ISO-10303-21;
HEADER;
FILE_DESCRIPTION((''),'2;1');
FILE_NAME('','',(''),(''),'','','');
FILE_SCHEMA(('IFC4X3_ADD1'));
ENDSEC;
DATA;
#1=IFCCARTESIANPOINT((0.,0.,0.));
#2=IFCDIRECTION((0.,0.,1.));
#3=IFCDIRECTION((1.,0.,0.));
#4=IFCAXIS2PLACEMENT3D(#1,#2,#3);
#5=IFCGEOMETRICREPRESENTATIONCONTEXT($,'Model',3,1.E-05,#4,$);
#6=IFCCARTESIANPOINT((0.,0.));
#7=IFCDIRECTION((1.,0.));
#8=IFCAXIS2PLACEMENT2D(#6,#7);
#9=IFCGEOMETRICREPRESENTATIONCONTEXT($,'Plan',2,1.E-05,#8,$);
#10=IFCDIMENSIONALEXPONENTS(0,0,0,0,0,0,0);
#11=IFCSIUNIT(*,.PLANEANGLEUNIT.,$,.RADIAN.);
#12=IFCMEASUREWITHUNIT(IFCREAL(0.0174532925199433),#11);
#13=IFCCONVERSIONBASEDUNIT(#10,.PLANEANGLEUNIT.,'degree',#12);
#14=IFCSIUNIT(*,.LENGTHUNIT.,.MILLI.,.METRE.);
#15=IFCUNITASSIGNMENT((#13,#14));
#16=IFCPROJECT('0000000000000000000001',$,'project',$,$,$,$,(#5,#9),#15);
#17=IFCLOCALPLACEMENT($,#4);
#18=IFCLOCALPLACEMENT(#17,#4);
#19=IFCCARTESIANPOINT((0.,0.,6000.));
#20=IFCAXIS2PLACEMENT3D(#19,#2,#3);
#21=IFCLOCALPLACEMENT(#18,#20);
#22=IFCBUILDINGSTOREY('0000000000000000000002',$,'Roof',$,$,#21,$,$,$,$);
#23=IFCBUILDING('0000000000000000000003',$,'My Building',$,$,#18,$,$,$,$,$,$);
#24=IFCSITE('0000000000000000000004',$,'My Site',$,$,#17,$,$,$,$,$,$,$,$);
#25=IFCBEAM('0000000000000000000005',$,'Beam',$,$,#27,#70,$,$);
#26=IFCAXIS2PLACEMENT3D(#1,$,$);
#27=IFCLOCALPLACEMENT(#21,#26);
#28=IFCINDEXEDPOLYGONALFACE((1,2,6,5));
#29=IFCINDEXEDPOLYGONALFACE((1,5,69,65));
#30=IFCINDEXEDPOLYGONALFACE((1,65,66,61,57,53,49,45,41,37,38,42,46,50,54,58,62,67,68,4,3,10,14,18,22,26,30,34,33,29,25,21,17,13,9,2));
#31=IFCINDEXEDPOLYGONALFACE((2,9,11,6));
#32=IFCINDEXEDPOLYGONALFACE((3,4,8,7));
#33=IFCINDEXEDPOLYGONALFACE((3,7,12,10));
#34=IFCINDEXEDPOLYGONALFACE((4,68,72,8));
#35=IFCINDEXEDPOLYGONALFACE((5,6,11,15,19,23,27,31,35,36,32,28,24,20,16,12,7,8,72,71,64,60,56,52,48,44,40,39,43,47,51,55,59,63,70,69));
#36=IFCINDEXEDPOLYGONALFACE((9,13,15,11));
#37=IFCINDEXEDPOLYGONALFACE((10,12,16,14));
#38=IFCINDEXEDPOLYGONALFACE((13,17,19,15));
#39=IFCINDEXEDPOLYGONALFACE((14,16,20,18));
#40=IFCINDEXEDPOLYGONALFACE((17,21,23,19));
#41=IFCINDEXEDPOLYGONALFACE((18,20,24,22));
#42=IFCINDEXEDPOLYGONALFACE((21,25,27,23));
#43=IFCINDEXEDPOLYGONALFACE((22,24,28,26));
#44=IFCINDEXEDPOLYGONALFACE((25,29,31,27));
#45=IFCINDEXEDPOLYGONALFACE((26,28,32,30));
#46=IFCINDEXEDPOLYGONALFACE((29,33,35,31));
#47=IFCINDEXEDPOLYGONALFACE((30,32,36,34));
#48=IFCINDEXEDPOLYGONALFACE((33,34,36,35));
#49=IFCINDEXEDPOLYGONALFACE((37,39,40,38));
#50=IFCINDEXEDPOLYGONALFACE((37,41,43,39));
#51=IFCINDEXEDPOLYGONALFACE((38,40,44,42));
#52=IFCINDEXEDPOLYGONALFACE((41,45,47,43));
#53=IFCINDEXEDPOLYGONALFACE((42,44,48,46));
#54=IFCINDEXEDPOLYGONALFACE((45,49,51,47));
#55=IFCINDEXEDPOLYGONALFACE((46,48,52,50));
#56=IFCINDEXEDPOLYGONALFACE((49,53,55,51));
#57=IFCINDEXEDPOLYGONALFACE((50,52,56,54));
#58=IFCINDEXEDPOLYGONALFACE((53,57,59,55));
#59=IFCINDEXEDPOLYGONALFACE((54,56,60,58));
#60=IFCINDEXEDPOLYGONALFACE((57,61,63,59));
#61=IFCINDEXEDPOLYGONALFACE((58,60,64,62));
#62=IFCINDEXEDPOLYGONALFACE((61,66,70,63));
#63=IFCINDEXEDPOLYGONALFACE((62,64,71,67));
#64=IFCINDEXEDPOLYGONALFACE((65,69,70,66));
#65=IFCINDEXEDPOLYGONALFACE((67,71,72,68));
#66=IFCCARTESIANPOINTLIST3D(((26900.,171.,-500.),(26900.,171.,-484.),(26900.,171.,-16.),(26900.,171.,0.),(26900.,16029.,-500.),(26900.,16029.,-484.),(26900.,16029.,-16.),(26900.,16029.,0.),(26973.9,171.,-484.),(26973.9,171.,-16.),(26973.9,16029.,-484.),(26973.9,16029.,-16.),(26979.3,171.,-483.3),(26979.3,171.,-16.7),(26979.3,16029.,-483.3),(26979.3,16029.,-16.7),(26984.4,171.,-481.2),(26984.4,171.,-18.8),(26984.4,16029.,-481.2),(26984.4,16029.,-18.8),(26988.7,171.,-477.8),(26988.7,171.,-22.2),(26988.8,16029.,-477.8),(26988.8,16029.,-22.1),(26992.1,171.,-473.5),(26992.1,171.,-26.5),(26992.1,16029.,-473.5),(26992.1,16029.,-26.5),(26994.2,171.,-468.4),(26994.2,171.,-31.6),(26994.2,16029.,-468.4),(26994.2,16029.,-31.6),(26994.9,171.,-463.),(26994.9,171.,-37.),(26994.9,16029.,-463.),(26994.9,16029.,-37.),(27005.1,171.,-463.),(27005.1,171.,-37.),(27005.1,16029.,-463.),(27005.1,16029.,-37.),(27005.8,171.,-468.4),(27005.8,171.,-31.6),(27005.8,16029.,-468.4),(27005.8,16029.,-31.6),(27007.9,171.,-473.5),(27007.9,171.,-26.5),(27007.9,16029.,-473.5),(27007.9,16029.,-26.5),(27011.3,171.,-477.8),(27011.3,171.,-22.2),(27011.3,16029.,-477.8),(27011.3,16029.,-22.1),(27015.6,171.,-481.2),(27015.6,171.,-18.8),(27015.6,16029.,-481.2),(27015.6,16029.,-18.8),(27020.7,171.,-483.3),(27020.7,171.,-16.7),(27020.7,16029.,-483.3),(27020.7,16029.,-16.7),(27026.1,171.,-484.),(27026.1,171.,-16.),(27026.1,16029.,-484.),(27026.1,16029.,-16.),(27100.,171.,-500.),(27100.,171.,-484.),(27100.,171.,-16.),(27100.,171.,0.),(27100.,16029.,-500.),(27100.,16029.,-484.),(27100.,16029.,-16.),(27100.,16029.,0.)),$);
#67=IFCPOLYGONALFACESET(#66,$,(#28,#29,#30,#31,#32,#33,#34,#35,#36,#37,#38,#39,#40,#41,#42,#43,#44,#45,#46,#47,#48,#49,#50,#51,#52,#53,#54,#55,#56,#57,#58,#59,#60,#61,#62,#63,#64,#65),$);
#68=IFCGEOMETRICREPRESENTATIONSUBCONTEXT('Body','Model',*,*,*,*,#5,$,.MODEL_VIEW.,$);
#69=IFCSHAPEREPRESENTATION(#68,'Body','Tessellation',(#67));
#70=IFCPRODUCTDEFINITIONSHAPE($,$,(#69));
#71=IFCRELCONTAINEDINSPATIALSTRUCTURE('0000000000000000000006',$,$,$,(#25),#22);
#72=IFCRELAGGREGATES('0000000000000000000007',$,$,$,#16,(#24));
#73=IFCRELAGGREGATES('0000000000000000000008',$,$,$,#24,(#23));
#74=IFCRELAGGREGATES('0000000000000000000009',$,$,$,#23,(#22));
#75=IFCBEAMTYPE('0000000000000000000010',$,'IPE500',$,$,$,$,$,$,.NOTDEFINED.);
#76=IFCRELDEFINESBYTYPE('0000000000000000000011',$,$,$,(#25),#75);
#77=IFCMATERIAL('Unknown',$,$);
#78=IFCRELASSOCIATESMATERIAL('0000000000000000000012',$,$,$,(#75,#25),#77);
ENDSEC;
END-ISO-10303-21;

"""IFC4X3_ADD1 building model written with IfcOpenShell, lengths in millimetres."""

from ifc_helpers import new_model, entity, si_unit, converted_unit, frame, origin_with_axes, origin_2d_with_axis, place, context, subcontext, project, spatial, i_section, extrude, material, material_profile, profile_set, profile_usage, type_object, element, save


model = new_model("IFC4X3_ADD1")

# Units and contexts
model_context = context("Model", 3, precision=1e-05, world=origin_with_axes())
plan_context = context("Plan", 2, precision=1e-05, world=origin_2d_with_axis())
body_context = subcontext(model_context, "Body", "Model", "MODEL_VIEW")
ifc_project = project(units=[converted_unit("PLANEANGLEUNIT", "degree", entity("IfcReal", 0.0174532925199433), si_unit("PLANEANGLEUNIT", "RADIAN"), dimensions=[0, 0, 0, 0, 0, 0, 0]), si_unit("LENGTHUNIT", "METRE", prefix="MILLI")], contexts=[model_context, plan_context])

# Site, building, storey
site_placement = place(None, origin_with_axes())
site = spatial("IfcSite", under=ifc_project, at=site_placement, Name="My Site")
building_placement = place(site_placement, origin_with_axes())
building = spatial("IfcBuilding", under=site, at=building_placement, Name="My Building")
storey_placement = place(building_placement, frame((0.0, 0.0, 6000.0), z_axis=(0.0, 0.0, 1.0), x_axis=(1.0, 0.0, 0.0)))
storey = spatial("IfcBuildingStorey", under=building, at=storey_placement, Name="Roof")

# Beam
ifc_material = material(Name="Unknown")
ifc_material_profile_1 = material_profile(ifc_material, i_section(OverallWidth=200.0, OverallDepth=500.0, WebThickness=10.2, FlangeThickness=16.0, FilletRadius=21.0))
ifc_profile_set_1 = profile_set([ifc_material_profile_1])
beam_type_1 = type_object("IfcBeamType", Name="IPE500", PredefinedType="NOTDEFINED", material=ifc_profile_set_1)
ifc_profile_usage_1 = profile_usage(ifc_profile_set_1, cardinal=8)
beam_1_placement = place(storey_placement, frame((27000.0, 171.0, 0.0), z_axis=(0.0, 1.0, 0.0), x_axis=(-1.0, 0.0, 0.0)))
element("IfcBeam", 1, at=beam_1_placement, inside=storey, type_object=beam_type_1, material=ifc_profile_usage_1, Name="Beam", context=body_context, shape_type="SweptSolid", body=[
    extrude(i_section(OverallWidth=200.0, OverallDepth=500.0, WebThickness=10.2, FlangeThickness=16.0, FilletRadius=21.0), frame((0.0, -250.0, 0.0), z_axis=(0.0, 0.0, 1.0), x_axis=(1.0, 0.0, 0.0)), (0.0, 0.0, 1.0), 15858.0),
])

save(model, "model.ifc")
